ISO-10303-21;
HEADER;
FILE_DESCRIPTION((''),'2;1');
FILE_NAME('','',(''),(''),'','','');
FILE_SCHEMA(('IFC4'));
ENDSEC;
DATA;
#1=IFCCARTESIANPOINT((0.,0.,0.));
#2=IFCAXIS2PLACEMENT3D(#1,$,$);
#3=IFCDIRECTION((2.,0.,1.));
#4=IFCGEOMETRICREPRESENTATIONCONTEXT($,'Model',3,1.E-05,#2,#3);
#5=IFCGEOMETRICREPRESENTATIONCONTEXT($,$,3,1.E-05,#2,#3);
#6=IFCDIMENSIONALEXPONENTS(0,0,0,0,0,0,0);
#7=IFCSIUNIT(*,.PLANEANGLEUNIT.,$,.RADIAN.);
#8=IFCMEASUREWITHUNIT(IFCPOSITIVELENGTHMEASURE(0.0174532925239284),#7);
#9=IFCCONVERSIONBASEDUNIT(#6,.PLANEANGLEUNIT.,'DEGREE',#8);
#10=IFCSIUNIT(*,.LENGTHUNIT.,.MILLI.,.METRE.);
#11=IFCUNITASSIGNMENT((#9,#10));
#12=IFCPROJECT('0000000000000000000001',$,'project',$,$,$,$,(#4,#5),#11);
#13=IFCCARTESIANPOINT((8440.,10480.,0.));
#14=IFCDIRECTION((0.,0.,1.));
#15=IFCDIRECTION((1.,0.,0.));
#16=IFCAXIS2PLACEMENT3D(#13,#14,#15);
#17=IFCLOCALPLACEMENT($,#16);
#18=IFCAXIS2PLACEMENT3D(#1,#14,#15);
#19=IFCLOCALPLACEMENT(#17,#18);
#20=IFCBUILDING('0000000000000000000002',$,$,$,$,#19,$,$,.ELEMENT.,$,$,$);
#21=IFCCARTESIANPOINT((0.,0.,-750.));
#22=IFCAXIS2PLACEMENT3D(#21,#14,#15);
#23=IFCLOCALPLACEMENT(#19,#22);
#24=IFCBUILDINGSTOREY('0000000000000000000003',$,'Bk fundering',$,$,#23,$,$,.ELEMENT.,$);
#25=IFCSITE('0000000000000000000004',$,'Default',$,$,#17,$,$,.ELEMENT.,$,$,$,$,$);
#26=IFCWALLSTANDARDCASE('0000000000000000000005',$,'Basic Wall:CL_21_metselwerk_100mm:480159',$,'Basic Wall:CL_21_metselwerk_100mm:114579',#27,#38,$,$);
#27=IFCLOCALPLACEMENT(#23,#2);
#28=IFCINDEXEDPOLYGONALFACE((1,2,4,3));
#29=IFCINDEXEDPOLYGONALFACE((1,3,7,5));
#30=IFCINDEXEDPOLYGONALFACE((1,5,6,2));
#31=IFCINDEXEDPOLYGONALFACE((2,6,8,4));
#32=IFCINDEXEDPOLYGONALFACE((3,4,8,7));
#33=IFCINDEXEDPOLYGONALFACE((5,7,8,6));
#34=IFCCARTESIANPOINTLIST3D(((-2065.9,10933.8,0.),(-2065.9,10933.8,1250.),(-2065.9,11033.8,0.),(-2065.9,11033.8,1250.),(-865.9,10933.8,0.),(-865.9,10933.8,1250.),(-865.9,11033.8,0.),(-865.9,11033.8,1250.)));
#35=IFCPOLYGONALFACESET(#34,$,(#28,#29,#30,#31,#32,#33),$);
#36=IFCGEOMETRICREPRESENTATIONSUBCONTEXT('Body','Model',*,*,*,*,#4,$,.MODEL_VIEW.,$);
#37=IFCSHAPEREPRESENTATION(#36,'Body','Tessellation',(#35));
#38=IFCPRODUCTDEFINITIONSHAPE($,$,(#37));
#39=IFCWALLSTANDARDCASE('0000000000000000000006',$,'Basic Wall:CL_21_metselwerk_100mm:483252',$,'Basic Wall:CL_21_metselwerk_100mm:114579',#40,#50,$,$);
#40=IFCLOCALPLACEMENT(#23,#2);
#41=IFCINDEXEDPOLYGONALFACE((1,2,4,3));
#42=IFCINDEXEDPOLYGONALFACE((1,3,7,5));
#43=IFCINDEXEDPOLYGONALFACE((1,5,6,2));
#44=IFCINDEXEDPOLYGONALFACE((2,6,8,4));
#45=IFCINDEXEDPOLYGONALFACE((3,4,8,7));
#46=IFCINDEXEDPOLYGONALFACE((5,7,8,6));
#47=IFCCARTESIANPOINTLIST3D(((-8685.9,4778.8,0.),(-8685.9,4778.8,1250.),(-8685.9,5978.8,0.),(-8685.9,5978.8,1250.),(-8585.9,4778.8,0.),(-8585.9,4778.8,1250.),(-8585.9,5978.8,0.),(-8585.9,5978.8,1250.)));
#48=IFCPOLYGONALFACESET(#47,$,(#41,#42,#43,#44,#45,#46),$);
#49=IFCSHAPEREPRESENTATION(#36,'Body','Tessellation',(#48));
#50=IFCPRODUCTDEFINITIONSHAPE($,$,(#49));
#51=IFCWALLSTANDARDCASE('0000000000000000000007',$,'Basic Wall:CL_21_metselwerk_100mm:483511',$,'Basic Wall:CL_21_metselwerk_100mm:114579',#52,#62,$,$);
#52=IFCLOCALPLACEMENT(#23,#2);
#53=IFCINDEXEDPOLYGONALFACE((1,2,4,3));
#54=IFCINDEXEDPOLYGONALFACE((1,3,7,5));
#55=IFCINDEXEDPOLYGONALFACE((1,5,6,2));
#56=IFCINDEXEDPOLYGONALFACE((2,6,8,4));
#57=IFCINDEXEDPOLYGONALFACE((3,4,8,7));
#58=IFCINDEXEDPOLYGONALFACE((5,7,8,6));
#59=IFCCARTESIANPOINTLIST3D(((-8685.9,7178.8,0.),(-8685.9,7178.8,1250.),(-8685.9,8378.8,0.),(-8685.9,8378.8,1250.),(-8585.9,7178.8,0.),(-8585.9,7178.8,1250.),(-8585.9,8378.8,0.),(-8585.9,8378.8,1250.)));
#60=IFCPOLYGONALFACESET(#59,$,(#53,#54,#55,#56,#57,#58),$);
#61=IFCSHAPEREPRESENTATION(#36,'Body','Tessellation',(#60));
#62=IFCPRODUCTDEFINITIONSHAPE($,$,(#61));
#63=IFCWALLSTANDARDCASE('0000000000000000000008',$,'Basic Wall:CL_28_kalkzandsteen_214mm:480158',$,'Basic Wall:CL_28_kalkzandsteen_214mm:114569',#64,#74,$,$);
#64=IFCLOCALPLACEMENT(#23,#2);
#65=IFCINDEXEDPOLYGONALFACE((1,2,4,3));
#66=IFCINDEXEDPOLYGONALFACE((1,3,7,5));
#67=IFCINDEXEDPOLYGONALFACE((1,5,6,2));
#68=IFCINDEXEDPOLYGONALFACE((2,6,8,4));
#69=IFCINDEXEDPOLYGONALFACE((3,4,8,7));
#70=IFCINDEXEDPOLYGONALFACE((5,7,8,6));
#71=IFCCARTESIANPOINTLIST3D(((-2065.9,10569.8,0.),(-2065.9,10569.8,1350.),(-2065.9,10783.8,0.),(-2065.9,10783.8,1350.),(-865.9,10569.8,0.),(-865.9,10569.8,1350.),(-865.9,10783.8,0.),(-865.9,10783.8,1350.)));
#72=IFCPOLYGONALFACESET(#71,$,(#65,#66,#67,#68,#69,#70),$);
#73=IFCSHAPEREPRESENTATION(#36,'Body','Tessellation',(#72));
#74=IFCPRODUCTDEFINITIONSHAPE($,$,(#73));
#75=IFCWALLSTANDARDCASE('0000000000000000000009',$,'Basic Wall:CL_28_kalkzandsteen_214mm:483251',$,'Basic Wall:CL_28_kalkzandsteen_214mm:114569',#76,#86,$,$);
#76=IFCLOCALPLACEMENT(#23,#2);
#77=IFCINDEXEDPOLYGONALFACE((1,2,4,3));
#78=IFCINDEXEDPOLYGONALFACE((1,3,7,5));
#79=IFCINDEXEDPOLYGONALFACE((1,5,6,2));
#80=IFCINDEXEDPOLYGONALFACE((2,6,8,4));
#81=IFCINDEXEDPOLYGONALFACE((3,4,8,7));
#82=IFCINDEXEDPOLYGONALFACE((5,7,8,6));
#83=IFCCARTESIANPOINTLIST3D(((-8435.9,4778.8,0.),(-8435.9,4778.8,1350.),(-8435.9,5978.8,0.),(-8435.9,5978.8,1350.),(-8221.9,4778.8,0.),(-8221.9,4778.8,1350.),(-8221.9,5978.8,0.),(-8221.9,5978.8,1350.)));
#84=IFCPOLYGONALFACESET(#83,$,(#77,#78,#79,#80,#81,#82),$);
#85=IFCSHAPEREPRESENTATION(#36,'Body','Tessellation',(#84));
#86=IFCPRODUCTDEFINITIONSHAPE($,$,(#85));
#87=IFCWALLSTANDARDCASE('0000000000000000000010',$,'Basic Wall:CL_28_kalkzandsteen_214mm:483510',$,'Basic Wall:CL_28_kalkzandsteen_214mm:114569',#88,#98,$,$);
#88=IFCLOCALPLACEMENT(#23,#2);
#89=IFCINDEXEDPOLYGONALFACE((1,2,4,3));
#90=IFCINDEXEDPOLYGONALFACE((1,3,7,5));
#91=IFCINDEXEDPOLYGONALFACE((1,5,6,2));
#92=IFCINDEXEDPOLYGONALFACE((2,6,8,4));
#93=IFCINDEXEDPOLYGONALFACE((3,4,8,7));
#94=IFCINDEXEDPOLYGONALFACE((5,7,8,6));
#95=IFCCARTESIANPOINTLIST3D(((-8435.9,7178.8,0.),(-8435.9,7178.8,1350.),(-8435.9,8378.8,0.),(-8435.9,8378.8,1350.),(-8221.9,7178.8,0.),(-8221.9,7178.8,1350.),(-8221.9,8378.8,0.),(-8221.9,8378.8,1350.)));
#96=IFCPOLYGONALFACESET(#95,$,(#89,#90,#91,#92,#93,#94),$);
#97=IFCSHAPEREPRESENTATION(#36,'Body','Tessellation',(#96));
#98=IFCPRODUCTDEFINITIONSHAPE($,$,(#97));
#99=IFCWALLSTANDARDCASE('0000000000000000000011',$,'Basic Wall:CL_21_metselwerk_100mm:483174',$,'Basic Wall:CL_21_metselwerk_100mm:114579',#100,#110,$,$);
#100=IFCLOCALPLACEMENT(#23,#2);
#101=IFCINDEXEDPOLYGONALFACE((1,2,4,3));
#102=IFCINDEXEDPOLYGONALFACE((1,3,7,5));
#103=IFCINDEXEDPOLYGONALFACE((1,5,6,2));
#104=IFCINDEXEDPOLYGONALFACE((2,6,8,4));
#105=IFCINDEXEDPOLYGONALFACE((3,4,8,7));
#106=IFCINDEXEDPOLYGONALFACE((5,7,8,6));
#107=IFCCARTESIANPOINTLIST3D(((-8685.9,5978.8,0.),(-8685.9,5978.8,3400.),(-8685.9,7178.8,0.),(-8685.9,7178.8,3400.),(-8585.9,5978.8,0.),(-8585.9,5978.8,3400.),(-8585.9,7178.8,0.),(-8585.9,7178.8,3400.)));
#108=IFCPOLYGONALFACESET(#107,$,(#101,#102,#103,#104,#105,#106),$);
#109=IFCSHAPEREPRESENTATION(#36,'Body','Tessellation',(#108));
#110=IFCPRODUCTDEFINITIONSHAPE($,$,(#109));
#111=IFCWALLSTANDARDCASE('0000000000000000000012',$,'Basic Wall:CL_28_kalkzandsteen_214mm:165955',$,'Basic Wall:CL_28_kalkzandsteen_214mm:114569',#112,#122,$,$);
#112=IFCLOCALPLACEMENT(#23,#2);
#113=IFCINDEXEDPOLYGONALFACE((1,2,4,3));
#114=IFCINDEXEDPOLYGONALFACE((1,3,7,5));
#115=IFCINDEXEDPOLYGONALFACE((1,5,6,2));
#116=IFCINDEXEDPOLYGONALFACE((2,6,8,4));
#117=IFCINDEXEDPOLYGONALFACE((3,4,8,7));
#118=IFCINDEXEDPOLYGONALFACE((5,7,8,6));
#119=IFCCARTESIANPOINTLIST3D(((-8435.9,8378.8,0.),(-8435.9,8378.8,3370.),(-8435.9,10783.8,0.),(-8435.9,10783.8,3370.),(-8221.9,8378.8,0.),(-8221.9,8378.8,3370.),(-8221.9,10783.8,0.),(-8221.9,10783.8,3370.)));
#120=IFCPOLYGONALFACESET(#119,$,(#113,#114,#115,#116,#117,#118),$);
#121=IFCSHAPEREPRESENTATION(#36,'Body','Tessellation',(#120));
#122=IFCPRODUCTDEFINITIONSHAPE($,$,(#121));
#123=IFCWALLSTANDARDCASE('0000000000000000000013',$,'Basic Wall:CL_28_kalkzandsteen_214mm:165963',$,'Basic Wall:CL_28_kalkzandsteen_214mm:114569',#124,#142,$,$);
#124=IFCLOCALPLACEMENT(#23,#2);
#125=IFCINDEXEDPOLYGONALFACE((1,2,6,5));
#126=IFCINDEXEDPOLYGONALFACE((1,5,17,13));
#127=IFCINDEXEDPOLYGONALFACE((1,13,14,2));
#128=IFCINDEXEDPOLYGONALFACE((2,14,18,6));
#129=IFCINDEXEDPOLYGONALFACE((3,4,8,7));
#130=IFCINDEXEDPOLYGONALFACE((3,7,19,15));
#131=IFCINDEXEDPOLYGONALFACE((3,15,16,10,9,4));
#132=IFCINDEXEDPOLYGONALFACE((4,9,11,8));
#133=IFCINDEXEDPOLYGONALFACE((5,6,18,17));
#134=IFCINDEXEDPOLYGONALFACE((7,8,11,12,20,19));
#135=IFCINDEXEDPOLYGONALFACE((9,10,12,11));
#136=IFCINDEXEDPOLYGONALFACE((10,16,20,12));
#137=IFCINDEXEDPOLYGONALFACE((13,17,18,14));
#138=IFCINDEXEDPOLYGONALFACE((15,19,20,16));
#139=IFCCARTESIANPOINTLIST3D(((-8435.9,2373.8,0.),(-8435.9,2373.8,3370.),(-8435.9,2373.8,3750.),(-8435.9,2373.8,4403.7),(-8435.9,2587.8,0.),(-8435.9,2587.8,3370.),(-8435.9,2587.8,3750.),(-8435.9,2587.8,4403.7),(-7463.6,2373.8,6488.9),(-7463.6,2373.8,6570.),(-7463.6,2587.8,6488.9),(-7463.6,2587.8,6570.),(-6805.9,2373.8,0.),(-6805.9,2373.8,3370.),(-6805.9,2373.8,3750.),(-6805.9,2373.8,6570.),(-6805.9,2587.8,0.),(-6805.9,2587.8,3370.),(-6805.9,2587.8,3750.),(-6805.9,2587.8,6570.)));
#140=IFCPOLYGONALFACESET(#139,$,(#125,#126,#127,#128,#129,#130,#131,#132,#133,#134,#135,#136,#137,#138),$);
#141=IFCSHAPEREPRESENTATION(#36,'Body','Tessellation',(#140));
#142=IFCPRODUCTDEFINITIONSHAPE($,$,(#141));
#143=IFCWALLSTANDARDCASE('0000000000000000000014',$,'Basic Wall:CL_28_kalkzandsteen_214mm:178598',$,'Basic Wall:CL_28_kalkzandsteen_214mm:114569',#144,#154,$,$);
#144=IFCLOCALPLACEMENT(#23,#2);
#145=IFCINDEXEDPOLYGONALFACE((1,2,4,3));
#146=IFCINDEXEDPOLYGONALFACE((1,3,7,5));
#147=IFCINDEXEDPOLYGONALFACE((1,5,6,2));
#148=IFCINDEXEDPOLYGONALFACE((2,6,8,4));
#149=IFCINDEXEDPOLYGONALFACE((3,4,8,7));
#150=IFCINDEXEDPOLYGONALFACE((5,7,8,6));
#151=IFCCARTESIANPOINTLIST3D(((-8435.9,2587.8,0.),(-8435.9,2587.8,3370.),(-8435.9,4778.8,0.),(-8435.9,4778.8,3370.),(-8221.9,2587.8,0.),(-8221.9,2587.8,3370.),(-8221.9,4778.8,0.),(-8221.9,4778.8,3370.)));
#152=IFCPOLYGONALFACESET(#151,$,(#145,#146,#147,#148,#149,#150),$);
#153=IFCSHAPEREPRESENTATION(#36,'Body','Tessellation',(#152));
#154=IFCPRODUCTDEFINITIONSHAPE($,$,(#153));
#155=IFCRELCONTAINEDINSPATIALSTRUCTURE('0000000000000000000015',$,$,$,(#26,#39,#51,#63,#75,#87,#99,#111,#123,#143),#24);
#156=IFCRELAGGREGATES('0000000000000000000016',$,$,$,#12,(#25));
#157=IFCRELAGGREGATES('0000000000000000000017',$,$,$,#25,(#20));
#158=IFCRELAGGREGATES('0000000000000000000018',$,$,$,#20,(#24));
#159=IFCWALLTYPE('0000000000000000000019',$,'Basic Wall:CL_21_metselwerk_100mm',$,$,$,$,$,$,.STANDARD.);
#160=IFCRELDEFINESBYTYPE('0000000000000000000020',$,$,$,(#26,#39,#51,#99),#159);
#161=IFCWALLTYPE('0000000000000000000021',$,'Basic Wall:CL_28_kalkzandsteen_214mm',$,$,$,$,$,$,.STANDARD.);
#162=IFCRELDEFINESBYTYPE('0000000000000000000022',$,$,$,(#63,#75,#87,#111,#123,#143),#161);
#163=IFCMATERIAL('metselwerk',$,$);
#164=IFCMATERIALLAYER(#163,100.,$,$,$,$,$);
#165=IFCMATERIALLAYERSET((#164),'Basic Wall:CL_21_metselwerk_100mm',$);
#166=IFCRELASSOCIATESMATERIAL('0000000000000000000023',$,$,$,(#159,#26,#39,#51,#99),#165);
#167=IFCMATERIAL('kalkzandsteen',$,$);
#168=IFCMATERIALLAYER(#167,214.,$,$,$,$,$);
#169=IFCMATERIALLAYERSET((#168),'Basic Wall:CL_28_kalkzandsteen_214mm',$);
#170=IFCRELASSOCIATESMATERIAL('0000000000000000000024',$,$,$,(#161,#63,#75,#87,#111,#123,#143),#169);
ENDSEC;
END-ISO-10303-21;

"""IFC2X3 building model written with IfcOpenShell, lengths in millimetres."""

from ifc_helpers import new_model, entity, si_unit, converted_unit, direction, frame, frame_2d, origin, origin_with_axes, place, context, subcontext, project, spatial, polyline, rectangle, extrude, clip, bounded_halfspace, source, transform, mapped, material, layer, layer_set, layer_usage, type_object, element, save


model = new_model("IFC2X3")

# Units and contexts
model_context = context("Model", 3, precision=1e-05, world=origin(), true_north=direction((2.0, 0.0, 1.0)))
context_of_model = context(None, 3, precision=1e-05, world=origin(), true_north=direction((2.0, 0.0, 1.0)))
body_context = subcontext(model_context, "Body", "Model", "MODEL_VIEW")
ifc_project = project(units=[converted_unit("PLANEANGLEUNIT", "DEGREE", entity("IfcPositiveLengthMeasure", 0.0174532925239284), si_unit("PLANEANGLEUNIT", "RADIAN"), dimensions=[0, 0, 0, 0, 0, 0, 0]), si_unit("LENGTHUNIT", "METRE", prefix="MILLI")], contexts=[model_context, context_of_model])

# Site, building, storey
site_placement = place(None, frame((8440.0, 10480.0, 0.0), z_axis=(0.0, 0.0, 1.0), x_axis=(1.0, 0.0, 0.0)))
site = spatial("IfcSite", under=ifc_project, at=site_placement, Name="Default", CompositionType="ELEMENT")
building_placement = place(site_placement, origin_with_axes())
building = spatial("IfcBuilding", under=site, at=building_placement, CompositionType="ELEMENT")
storey_placement = place(building_placement, frame((0.0, 0.0, -750.0), z_axis=(0.0, 0.0, 1.0), x_axis=(1.0, 0.0, 0.0)))
storey = spatial("IfcBuildingStorey", under=building, at=storey_placement, Name="Bk fundering", CompositionType="ELEMENT")

# Walls
ifc_material_1 = material(Name="metselwerk")
ifc_layer_1 = layer(ifc_material_1, 100.0)
ifc_layer_set_1 = layer_set([ifc_layer_1], Name="Basic Wall:CL_21_metselwerk_100mm")
ifc_layer_usage_1 = layer_usage(ifc_layer_set_1, "AXIS2", "NEGATIVE", 50.0)
wall_type_1 = type_object("IfcWallType", Name="Basic Wall:CL_21_metselwerk_100mm", PredefinedType="STANDARD", material=ifc_layer_set_1)
shared_shape_1 = source(origin(), body_context, "Body", "SweptSolid", [
    extrude(rectangle(XDim=1200.0, YDim=100.0, at=frame_2d((600.0, 0.0), x_axis=(-1.0, 0.0))), origin(), (0.0, 0.0, 1.0), 1250.0),
])
wall_1_placement = place(storey_placement, frame((-865.9, 10983.8, 0.0), z_axis=(0.0, 0.0, 1.0), x_axis=(-1.0, 0.0, 0.0)))
element("IfcWallStandardCase", 1, at=wall_1_placement, inside=storey, type_object=wall_type_1, material=ifc_layer_usage_1, Name="Basic Wall:CL_21_metselwerk_100mm:480159", ObjectType="Basic Wall:CL_21_metselwerk_100mm:114579", context=body_context, shape_type="MappedRepresentation", body=[
    mapped(shared_shape_1, transform((0.0, 0.0, 0.0))),
])
ifc_layer_usage_2 = layer_usage(ifc_layer_set_1, "AXIS2", "NEGATIVE", 50.0)
wall_2_placement = place(storey_placement, frame((-8635.9, 5978.8, 0.0), z_axis=(0.0, 0.0, 1.0), x_axis=(0.0, -1.0, 0.0)))
element("IfcWallStandardCase", 2, at=wall_2_placement, inside=storey, type_object=wall_type_1, material=ifc_layer_usage_2, Name="Basic Wall:CL_21_metselwerk_100mm:483252", ObjectType="Basic Wall:CL_21_metselwerk_100mm:114579", context=body_context, shape_type="MappedRepresentation", body=[
    mapped(shared_shape_1, transform((0.0, 0.0, 0.0))),
])
ifc_layer_usage_3 = layer_usage(ifc_layer_set_1, "AXIS2", "NEGATIVE", 50.0)
wall_3_placement = place(storey_placement, frame((-8635.9, 8378.8, 0.0), z_axis=(0.0, 0.0, 1.0), x_axis=(0.0, -1.0, 0.0)))
element("IfcWallStandardCase", 3, at=wall_3_placement, inside=storey, type_object=wall_type_1, material=ifc_layer_usage_3, Name="Basic Wall:CL_21_metselwerk_100mm:483511", ObjectType="Basic Wall:CL_21_metselwerk_100mm:114579", context=body_context, shape_type="MappedRepresentation", body=[
    mapped(shared_shape_1, transform((0.0, 0.0, 0.0))),
])
ifc_material_2 = material(Name="kalkzandsteen")
ifc_layer_2 = layer(ifc_material_2, 214.0)
ifc_layer_set_2 = layer_set([ifc_layer_2], Name="Basic Wall:CL_28_kalkzandsteen_214mm")
ifc_layer_usage_4 = layer_usage(ifc_layer_set_2, "AXIS2", "NEGATIVE", 107.0)
wall_type_2 = type_object("IfcWallType", Name="Basic Wall:CL_28_kalkzandsteen_214mm", PredefinedType="STANDARD", material=ifc_layer_set_2)
shared_shape_2 = source(origin(), body_context, "Body", "SweptSolid", [
    extrude(rectangle(XDim=1200.0, YDim=214.0, at=frame_2d((600.0, 0.0), x_axis=(-1.0, 0.0))), origin(), (0.0, 0.0, 1.0), 1350.0),
])
wall_4_placement = place(storey_placement, frame((-865.9, 10676.8, 0.0), z_axis=(0.0, 0.0, 1.0), x_axis=(-1.0, 0.0, 0.0)))
element("IfcWallStandardCase", 4, at=wall_4_placement, inside=storey, type_object=wall_type_2, material=ifc_layer_usage_4, Name="Basic Wall:CL_28_kalkzandsteen_214mm:480158", ObjectType="Basic Wall:CL_28_kalkzandsteen_214mm:114569", context=body_context, shape_type="MappedRepresentation", body=[
    mapped(shared_shape_2, transform((0.0, 0.0, 0.0))),
])
ifc_layer_usage_5 = layer_usage(ifc_layer_set_2, "AXIS2", "NEGATIVE", 107.0)
wall_5_placement = place(storey_placement, frame((-8328.9, 5978.8, 0.0), z_axis=(0.0, 0.0, 1.0), x_axis=(0.0, -1.0, 0.0)))
element("IfcWallStandardCase", 5, at=wall_5_placement, inside=storey, type_object=wall_type_2, material=ifc_layer_usage_5, Name="Basic Wall:CL_28_kalkzandsteen_214mm:483251", ObjectType="Basic Wall:CL_28_kalkzandsteen_214mm:114569", context=body_context, shape_type="MappedRepresentation", body=[
    mapped(shared_shape_2, transform((0.0, 0.0, 0.0))),
])
ifc_layer_usage_6 = layer_usage(ifc_layer_set_2, "AXIS2", "NEGATIVE", 107.0)
wall_6_placement = place(storey_placement, frame((-8328.9, 8378.8, 0.0), z_axis=(0.0, 0.0, 1.0), x_axis=(0.0, -1.0, 0.0)))
element("IfcWallStandardCase", 6, at=wall_6_placement, inside=storey, type_object=wall_type_2, material=ifc_layer_usage_6, Name="Basic Wall:CL_28_kalkzandsteen_214mm:483510", ObjectType="Basic Wall:CL_28_kalkzandsteen_214mm:114569", context=body_context, shape_type="MappedRepresentation", body=[
    mapped(shared_shape_2, transform((0.0, 0.0, 0.0))),
])
ifc_layer_usage_7 = layer_usage(ifc_layer_set_1, "AXIS2", "NEGATIVE", 50.0)
shared_shape_3 = source(origin(), body_context, "Body", "SweptSolid", [
    extrude(rectangle(XDim=1200.0, YDim=100.0, at=frame_2d((600.0, 0.0), x_axis=(-1.0, 0.0))), origin(), (0.0, 0.0, 1.0), 3400.0),
])
wall_7_placement = place(storey_placement, frame((-8635.9, 7178.8, 0.0), z_axis=(0.0, 0.0, 1.0), x_axis=(0.0, -1.0, 0.0)))
element("IfcWallStandardCase", 7, at=wall_7_placement, inside=storey, type_object=wall_type_1, material=ifc_layer_usage_7, Name="Basic Wall:CL_21_metselwerk_100mm:483174", ObjectType="Basic Wall:CL_21_metselwerk_100mm:114579", context=body_context, shape_type="MappedRepresentation", body=[
    mapped(shared_shape_3, transform((0.0, 0.0, 0.0))),
])
ifc_layer_usage_8 = layer_usage(ifc_layer_set_2, "AXIS2", "NEGATIVE", 107.0)
wall_8_placement = place(storey_placement, frame((-8328.9, 10783.8, 0.0), z_axis=(0.0, 0.0, 1.0), x_axis=(0.0, -1.0, 0.0)))
element("IfcWallStandardCase", 8, at=wall_8_placement, inside=storey, type_object=wall_type_2, material=ifc_layer_usage_8, Name="Basic Wall:CL_28_kalkzandsteen_214mm:165955", ObjectType="Basic Wall:CL_28_kalkzandsteen_214mm:114569", context=body_context, shape_type="Clipping", body=[
    clip(extrude(rectangle(XDim=2405.0, YDim=214.0, at=frame_2d((1202.5, 0.0), x_axis=(-1.0, 0.0))), origin(), (0.0, 0.0, 1.0), 3370.0), bounded_halfspace(frame((0.0, -107.0, 3370.0), z_axis=(0.0, 0.0, -1.0), x_axis=(0.0, 1.0, 0.0)), True, frame((0.0, -107.0, 3370.0)), polyline([(0.0, 0.0), (2405.0, 0.0), (2405.0, 214.0), (214.0, 214.0), (0.0, 214.0), (0.0, 0.0)]))),
])

# Wall, opening
ifc_layer_usage_9 = layer_usage(ifc_layer_set_2, "AXIS2", "NEGATIVE", 107.0)
wall_9_placement = place(storey_placement, frame((-8435.9, 2480.8, 0.0), z_axis=(0.0, 0.0, 1.0), x_axis=(1.0, 0.0, 0.0)))
wall_9 = element("IfcWallStandardCase", 9, at=wall_9_placement, inside=storey, type_object=wall_type_2, material=ifc_layer_usage_9, Name="Basic Wall:CL_28_kalkzandsteen_214mm:165963", ObjectType="Basic Wall:CL_28_kalkzandsteen_214mm:114569", context=body_context, shape_type="Clipping", body=[
    clip(extrude(rectangle(XDim=1630.0, YDim=214.0, at=frame_2d((815.0, 0.0), x_axis=(-1.0, 0.0))), origin(), (0.0, 0.0, 1.0), 6570.0), bounded_halfspace(frame((0.0, -107.0, 4403.7), z_axis=(-0.906308, 0.0, 0.422618), x_axis=(0.0, -1.0, 0.0)), False, frame((0.0, -107.0, 4403.7)), polyline([(0.0, 0.0), (972.3, 0.0), (972.3, 214.0), (0.0, 214.0), (0.0, 0.0)]))),
])
opening_1_placement = place(wall_9_placement, origin_with_axes())
element("IfcOpeningElement", 10, at=opening_1_placement, cuts=wall_9, ObjectType="Opening", context=body_context, shape_type="SweptSolid", body=[
    extrude(rectangle(XDim=1630.0, YDim=214.0, at=frame_2d((120.2, -21.4), x_axis=(1.0, 0.0))), frame((694.8, 21.4, 3370.0)), (0.0, 0.0, 1.0), 380.0),
])

# Wall
ifc_layer_usage_10 = layer_usage(ifc_layer_set_2, "AXIS2", "NEGATIVE", 107.0)
wall_10_placement = place(storey_placement, frame((-8328.9, 4778.8, 0.0), z_axis=(0.0, 0.0, 1.0), x_axis=(0.0, -1.0, 0.0)))
element("IfcWallStandardCase", 11, at=wall_10_placement, inside=storey, type_object=wall_type_2, material=ifc_layer_usage_10, Name="Basic Wall:CL_28_kalkzandsteen_214mm:178598", ObjectType="Basic Wall:CL_28_kalkzandsteen_214mm:114569", context=body_context, shape_type="Clipping", body=[
    clip(extrude(rectangle(XDim=2191.0, YDim=214.0, at=frame_2d((1095.5, 0.0), x_axis=(-1.0, 0.0))), origin(), (0.0, 0.0, 1.0), 3370.0), bounded_halfspace(frame((0.0, -107.0, 3370.0), z_axis=(0.0, 0.0, -1.0), x_axis=(0.0, 1.0, 0.0)), True, frame((0.0, -107.0, 3370.0)), polyline([(0.0, 0.0), (2191.0, 0.0), (2191.0, 214.0), (0.0, 214.0), (0.0, 0.0)]))),
])

save(model, "model.ifc")
